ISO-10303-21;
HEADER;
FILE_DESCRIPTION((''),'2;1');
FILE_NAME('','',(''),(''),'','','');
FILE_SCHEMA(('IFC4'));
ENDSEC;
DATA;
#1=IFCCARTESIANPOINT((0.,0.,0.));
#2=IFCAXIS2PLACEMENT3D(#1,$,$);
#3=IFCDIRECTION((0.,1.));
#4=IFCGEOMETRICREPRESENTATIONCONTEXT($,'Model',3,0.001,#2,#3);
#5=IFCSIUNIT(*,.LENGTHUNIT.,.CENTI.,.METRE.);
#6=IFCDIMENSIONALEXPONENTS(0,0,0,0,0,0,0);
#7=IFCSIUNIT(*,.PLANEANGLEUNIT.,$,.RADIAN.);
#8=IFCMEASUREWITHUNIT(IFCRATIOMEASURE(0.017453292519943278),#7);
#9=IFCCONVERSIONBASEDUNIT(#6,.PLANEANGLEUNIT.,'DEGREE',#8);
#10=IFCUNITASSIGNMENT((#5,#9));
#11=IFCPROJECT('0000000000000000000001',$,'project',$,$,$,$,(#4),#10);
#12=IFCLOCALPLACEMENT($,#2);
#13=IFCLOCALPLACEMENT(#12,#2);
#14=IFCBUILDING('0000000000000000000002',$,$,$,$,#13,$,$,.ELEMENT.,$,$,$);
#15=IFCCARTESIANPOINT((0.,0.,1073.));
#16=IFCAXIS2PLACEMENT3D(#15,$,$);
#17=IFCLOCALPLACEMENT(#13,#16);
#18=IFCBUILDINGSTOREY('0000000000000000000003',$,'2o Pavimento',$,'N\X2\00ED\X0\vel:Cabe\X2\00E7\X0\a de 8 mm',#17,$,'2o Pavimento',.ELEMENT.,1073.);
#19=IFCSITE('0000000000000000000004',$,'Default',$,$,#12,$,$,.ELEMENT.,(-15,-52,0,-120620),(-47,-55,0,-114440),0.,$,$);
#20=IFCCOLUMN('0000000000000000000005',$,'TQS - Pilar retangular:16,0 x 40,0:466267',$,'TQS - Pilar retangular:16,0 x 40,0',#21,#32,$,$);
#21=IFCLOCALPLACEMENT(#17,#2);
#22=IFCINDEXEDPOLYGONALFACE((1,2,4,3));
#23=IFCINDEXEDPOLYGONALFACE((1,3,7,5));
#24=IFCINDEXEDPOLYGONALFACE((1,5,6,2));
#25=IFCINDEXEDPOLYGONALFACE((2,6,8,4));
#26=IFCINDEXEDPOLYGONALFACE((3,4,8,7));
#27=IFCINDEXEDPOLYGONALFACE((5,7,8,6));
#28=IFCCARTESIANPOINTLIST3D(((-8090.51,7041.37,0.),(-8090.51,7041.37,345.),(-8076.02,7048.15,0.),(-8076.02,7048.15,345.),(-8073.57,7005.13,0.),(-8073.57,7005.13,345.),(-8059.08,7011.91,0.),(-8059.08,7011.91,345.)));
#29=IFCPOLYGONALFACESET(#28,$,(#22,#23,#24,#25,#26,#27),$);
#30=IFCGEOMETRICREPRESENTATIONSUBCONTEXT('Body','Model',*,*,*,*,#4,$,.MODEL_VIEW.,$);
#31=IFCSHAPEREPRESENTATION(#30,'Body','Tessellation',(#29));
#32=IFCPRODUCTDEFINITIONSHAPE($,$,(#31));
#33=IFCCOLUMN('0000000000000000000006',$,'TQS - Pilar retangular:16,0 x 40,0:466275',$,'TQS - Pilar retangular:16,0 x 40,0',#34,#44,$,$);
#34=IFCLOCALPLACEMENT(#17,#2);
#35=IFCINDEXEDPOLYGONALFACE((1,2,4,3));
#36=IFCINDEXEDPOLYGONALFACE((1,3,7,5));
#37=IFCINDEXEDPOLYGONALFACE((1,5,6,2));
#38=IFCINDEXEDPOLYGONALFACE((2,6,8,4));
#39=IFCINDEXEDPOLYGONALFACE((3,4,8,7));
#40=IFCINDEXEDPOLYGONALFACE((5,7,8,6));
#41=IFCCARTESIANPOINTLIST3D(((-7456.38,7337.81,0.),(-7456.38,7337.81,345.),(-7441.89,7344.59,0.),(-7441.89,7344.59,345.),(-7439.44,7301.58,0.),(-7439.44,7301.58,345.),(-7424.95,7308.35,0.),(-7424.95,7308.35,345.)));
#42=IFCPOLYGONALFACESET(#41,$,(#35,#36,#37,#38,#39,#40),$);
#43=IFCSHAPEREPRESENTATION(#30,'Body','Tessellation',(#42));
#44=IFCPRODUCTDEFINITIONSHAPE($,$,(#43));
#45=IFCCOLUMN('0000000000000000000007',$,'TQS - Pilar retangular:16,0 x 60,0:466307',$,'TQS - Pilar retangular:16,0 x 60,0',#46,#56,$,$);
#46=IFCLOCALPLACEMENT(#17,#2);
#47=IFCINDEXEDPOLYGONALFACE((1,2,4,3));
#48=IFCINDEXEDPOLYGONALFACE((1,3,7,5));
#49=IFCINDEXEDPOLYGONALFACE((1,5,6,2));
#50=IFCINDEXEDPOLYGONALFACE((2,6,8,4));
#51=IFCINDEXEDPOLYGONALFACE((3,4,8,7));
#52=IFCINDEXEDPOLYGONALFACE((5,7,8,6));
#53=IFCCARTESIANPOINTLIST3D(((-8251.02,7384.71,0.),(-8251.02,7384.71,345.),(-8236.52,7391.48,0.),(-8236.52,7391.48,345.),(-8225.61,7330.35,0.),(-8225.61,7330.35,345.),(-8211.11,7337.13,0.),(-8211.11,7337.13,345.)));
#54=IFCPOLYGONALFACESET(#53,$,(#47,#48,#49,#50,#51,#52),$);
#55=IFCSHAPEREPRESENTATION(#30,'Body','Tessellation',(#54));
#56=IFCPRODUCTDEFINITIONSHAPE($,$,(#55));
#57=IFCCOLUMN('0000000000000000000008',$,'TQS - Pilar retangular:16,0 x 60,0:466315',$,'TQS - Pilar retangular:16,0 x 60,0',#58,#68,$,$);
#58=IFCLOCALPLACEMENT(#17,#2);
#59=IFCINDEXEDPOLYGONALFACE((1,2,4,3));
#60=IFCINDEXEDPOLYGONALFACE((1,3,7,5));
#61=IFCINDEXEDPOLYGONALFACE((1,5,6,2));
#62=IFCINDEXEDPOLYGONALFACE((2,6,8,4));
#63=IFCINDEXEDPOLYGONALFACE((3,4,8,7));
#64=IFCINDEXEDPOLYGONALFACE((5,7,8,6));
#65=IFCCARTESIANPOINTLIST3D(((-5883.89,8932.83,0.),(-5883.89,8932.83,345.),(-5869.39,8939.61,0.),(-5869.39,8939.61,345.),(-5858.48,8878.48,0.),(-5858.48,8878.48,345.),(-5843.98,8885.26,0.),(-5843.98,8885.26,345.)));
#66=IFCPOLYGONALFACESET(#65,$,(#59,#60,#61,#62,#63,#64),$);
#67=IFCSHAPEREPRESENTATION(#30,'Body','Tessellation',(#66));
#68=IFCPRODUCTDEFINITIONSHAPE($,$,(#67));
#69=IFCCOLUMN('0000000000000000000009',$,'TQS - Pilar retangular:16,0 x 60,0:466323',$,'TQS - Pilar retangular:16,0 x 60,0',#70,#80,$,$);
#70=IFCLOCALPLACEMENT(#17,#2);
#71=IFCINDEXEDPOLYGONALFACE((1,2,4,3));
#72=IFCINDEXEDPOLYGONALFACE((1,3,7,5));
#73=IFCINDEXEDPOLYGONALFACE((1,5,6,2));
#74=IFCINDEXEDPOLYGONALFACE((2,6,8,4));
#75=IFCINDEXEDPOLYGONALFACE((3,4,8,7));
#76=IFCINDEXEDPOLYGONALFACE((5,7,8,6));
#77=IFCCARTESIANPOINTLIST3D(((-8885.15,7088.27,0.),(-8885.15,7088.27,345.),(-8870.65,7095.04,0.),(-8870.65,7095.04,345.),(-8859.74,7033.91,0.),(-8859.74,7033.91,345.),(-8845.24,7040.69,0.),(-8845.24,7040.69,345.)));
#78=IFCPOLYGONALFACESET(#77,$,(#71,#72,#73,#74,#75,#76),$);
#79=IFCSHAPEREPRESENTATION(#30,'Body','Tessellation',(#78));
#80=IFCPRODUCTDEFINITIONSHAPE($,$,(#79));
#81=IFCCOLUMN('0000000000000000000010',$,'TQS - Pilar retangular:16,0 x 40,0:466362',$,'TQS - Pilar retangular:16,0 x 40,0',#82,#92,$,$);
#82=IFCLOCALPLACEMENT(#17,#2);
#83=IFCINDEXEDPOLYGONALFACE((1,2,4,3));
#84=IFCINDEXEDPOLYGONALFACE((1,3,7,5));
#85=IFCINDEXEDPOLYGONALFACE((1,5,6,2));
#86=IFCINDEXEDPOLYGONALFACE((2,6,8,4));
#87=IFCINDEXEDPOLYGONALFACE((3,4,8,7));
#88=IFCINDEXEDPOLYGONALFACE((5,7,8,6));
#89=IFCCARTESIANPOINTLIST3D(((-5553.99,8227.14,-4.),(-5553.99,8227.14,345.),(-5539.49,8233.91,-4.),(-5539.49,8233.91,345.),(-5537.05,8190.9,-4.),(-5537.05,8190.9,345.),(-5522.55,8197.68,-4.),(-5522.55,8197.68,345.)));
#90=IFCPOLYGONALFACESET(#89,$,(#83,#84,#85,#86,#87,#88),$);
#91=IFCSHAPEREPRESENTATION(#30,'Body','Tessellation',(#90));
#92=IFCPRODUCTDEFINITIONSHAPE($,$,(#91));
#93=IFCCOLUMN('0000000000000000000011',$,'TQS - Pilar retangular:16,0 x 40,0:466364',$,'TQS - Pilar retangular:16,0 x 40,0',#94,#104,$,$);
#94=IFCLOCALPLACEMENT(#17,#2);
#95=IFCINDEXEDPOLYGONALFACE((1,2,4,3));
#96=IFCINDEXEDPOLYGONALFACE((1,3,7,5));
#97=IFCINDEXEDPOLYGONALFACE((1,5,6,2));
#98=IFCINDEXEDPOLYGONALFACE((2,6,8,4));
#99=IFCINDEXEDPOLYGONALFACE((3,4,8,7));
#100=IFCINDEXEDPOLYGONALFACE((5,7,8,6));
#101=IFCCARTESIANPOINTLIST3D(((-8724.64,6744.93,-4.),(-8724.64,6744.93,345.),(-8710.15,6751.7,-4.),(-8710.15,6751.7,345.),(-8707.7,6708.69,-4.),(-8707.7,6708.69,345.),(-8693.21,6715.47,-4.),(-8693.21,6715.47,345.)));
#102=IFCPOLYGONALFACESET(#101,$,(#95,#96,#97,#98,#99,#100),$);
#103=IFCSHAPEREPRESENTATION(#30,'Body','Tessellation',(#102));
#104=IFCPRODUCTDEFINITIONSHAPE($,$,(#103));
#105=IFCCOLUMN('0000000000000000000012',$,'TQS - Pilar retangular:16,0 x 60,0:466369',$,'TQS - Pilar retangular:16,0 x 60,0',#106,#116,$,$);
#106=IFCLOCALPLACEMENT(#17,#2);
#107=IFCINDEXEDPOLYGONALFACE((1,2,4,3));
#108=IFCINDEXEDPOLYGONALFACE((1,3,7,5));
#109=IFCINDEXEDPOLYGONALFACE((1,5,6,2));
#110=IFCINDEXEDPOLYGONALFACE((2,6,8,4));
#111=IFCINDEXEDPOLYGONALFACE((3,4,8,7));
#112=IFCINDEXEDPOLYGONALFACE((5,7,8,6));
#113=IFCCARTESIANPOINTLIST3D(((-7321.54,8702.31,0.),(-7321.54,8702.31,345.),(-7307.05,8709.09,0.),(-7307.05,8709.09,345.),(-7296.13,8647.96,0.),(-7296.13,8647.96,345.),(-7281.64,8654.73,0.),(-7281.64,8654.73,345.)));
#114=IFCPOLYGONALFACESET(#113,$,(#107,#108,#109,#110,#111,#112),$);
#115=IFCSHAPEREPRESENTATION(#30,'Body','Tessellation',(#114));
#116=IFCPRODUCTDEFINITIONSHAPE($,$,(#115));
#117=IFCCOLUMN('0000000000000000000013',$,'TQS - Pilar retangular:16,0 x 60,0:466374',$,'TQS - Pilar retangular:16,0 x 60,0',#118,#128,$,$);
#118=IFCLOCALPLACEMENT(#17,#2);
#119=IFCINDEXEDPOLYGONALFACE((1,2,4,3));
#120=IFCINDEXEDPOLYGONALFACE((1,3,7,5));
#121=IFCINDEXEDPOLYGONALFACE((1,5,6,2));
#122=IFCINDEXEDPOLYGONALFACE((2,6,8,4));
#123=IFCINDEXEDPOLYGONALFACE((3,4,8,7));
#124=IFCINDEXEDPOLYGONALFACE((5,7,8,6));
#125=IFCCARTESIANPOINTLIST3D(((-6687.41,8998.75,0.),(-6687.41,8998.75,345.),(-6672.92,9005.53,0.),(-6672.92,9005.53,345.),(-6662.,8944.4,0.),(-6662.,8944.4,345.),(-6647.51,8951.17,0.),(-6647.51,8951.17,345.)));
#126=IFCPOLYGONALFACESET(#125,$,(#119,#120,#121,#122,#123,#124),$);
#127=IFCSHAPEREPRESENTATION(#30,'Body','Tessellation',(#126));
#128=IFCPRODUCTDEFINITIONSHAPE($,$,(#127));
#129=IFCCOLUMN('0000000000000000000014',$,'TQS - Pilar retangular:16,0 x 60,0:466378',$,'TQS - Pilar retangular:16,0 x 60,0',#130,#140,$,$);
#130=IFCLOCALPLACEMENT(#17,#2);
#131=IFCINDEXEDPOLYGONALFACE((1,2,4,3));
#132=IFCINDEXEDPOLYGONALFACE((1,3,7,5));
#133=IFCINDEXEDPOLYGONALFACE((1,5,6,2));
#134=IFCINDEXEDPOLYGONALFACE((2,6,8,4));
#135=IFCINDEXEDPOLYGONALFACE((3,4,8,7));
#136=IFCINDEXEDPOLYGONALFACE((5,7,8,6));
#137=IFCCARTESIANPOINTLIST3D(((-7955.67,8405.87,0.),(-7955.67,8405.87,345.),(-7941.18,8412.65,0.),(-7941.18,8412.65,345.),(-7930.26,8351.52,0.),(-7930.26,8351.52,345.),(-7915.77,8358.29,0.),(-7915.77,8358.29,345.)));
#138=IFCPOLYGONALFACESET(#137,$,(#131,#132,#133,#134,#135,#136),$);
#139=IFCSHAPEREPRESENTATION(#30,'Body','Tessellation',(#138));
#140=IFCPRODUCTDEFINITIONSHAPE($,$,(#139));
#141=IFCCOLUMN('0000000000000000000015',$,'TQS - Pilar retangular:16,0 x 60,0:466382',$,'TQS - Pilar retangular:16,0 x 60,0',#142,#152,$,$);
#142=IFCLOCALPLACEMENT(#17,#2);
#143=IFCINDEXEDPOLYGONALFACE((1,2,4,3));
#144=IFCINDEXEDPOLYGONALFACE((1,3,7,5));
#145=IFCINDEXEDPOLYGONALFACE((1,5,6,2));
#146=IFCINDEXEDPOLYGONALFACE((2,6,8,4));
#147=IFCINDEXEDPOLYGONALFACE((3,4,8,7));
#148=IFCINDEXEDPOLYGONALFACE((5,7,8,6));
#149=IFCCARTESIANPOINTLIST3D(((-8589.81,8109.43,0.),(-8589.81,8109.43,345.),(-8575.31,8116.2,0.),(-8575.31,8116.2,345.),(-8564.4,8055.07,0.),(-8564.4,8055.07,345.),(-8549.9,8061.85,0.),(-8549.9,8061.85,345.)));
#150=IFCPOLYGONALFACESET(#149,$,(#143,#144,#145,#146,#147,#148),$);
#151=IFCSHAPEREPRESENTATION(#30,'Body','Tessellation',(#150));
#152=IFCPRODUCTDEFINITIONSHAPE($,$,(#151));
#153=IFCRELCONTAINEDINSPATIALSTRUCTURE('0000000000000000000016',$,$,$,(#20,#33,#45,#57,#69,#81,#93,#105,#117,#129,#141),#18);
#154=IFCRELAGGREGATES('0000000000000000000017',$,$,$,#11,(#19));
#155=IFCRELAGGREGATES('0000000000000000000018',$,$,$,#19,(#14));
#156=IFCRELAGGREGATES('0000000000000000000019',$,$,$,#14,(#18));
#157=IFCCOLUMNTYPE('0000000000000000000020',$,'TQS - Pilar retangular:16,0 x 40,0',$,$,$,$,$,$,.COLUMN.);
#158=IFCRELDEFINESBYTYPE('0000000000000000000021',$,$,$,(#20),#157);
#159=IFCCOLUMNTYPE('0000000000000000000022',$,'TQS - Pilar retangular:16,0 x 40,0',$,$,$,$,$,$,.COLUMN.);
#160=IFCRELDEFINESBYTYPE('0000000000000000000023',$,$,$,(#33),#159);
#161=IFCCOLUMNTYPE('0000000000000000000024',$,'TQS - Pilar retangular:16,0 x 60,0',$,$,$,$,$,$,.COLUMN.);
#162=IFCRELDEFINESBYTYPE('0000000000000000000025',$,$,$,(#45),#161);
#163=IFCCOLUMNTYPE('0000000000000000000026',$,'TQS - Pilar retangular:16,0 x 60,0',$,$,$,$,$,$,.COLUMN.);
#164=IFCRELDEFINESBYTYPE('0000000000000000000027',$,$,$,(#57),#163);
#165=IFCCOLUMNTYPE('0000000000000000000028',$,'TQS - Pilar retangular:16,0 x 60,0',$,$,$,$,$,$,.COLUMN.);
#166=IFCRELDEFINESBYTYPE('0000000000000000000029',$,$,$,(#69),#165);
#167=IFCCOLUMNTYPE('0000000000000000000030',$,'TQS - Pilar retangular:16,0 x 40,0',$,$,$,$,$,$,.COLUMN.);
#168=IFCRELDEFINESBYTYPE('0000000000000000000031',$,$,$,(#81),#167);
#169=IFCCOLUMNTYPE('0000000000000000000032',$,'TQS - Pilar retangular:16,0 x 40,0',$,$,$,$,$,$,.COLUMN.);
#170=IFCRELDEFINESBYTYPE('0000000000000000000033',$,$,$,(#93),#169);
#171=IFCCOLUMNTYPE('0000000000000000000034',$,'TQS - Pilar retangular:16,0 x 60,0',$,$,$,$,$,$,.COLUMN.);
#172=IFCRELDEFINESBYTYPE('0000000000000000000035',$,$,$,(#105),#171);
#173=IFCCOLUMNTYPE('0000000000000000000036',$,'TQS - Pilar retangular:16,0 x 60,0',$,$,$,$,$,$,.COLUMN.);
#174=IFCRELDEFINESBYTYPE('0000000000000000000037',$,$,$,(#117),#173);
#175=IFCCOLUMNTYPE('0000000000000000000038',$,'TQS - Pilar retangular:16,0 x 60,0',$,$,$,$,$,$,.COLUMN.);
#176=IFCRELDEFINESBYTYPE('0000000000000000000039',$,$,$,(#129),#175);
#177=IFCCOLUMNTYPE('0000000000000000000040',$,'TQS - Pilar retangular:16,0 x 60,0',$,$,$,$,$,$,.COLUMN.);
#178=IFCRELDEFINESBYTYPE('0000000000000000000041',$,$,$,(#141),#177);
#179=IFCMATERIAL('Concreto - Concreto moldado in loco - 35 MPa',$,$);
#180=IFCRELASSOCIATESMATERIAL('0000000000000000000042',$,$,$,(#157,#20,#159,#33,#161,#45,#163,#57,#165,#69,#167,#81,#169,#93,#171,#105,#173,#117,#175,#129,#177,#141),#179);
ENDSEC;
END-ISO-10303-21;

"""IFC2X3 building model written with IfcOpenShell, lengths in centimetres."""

from ifc_helpers import new_model, entity, si_unit, converted_unit, direction, frame, frame_2d, origin, origin_2d_with_axis, place, context, subcontext, project, spatial, rectangle, extrude, source, transform, mapped, material, type_object, type_shapes, element, save


model = new_model("IFC2X3")

# Units and contexts
model_context = context("Model", 3, precision=0.001, world=origin(), true_north=direction((0.0, 1.0)))
body_context = subcontext(model_context, "Body", "Model", "MODEL_VIEW")
ifc_project = project(units=[si_unit("LENGTHUNIT", "METRE", prefix="CENTI"), converted_unit("PLANEANGLEUNIT", "DEGREE", entity("IfcRatioMeasure", 0.017453292519943278), si_unit("PLANEANGLEUNIT", "RADIAN"), dimensions=[0, 0, 0, 0, 0, 0, 0])], contexts=[model_context])

# Site, building, storey
site_placement = place(None, origin())
site = spatial("IfcSite", under=ifc_project, at=site_placement, Name="Default", CompositionType="ELEMENT", RefLatitude=(-15, -52, 0, -120620), RefLongitude=(-47, -55, 0, -114440), RefElevation=0.0)
building_placement = place(site_placement, origin())
building = spatial("IfcBuilding", under=site, at=building_placement, CompositionType="ELEMENT")
storey_placement = place(building_placement, frame((0.0, 0.0, 1073.0)))
storey = spatial("IfcBuildingStorey", under=building, at=storey_placement, Name="2o Pavimento", ObjectType="Nível:Cabeça de 8 mm", LongName="2o Pavimento", CompositionType="ELEMENT", Elevation=1073.0)

# Columns
ifc_material = material(Name="Concreto - Concreto moldado in loco - 35 MPa")
column_type_1 = type_object("IfcColumnType", Name="TQS - Pilar retangular:16,0 x 40,0", PredefinedType="COLUMN", material=ifc_material)
shared_shape_1 = source(origin(), body_context, "Body", "SweptSolid", [
    extrude(rectangle(XDim=40.0, YDim=16.0, at=origin_2d_with_axis()), frame((-8074.8, 7026.64, 1073.0), z_axis=(0.0, 0.0, 1.0), x_axis=(-0.423488, 0.905902, 0.0)), (0.0, 0.0, 1.0), 345.0),
])
type_shapes(column_type_1, [shared_shape_1])
column_1_placement = place(storey_placement, frame((0.0, 0.0, -1073.0)))
element("IfcColumn", 1, at=column_1_placement, inside=storey, type_object=column_type_1, material=ifc_material, Name="TQS - Pilar retangular:16,0 x 40,0:466267", ObjectType="TQS - Pilar retangular:16,0 x 40,0", context=body_context, shape_type="MappedRepresentation", body=[
    mapped(shared_shape_1, transform((0.0, 0.0, 0.0), scale=1.0)),
])
column_type_2 = type_object("IfcColumnType", Name="TQS - Pilar retangular:16,0 x 40,0", PredefinedType="COLUMN", material=ifc_material)
shared_shape_2 = source(origin(), body_context, "Body", "SweptSolid", [
    extrude(rectangle(XDim=40.0, YDim=16.0, at=origin_2d_with_axis()), frame((-7440.67, 7323.08, 1073.0), z_axis=(0.0, 0.0, 1.0), x_axis=(-0.423488, 0.905902, 0.0)), (0.0, 0.0, 1.0), 345.0),
])
type_shapes(column_type_2, [shared_shape_2])
column_2_placement = place(storey_placement, frame((0.0, 0.0, -1073.0)))
element("IfcColumn", 2, at=column_2_placement, inside=storey, type_object=column_type_2, material=ifc_material, Name="TQS - Pilar retangular:16,0 x 40,0:466275", ObjectType="TQS - Pilar retangular:16,0 x 40,0", context=body_context, shape_type="MappedRepresentation", body=[
    mapped(shared_shape_2, transform((0.0, 0.0, 0.0), scale=1.0)),
])
column_type_3 = type_object("IfcColumnType", Name="TQS - Pilar retangular:16,0 x 60,0", PredefinedType="COLUMN", material=ifc_material)
shared_shape_3 = source(origin(), body_context, "Body", "SweptSolid", [
    extrude(rectangle(XDim=60.0, YDim=16.0, at=origin_2d_with_axis()), frame((-8231.06, 7360.92, 1073.0), z_axis=(0.0, 0.0, 1.0), x_axis=(-0.423488, 0.905902, 0.0)), (0.0, 0.0, 1.0), 345.0),
])
type_shapes(column_type_3, [shared_shape_3])
column_3_placement = place(storey_placement, frame((0.0, 0.0, -1073.0)))
element("IfcColumn", 3, at=column_3_placement, inside=storey, type_object=column_type_3, material=ifc_material, Name="TQS - Pilar retangular:16,0 x 60,0:466307", ObjectType="TQS - Pilar retangular:16,0 x 60,0", context=body_context, shape_type="MappedRepresentation", body=[
    mapped(shared_shape_3, transform((0.0, 0.0, 0.0), scale=1.0)),
])
column_type_4 = type_object("IfcColumnType", Name="TQS - Pilar retangular:16,0 x 60,0", PredefinedType="COLUMN", material=ifc_material)
shared_shape_4 = source(origin(), body_context, "Body", "SweptSolid", [
    extrude(rectangle(XDim=60.0, YDim=16.0, at=origin_2d_with_axis()), frame((-5863.93, 8909.04, 1073.0), z_axis=(0.0, 0.0, 1.0), x_axis=(-0.423488, 0.905902, 0.0)), (0.0, 0.0, 1.0), 345.0),
])
type_shapes(column_type_4, [shared_shape_4])
column_4_placement = place(storey_placement, frame((0.0, 0.0, -1073.0)))
element("IfcColumn", 4, at=column_4_placement, inside=storey, type_object=column_type_4, material=ifc_material, Name="TQS - Pilar retangular:16,0 x 60,0:466315", ObjectType="TQS - Pilar retangular:16,0 x 60,0", context=body_context, shape_type="MappedRepresentation", body=[
    mapped(shared_shape_4, transform((0.0, 0.0, 0.0), scale=1.0)),
])
column_type_5 = type_object("IfcColumnType", Name="TQS - Pilar retangular:16,0 x 60,0", PredefinedType="COLUMN", material=ifc_material)
shared_shape_5 = source(origin(), body_context, "Body", "SweptSolid", [
    extrude(rectangle(XDim=60.0, YDim=16.0, at=origin_2d_with_axis()), frame((-8865.19, 7064.48, 1073.0), z_axis=(0.0, 0.0, 1.0), x_axis=(-0.423488, 0.905902, 0.0)), (0.0, 0.0, 1.0), 345.0),
])
type_shapes(column_type_5, [shared_shape_5])
column_5_placement = place(storey_placement, frame((0.0, 0.0, -1073.0)))
element("IfcColumn", 5, at=column_5_placement, inside=storey, type_object=column_type_5, material=ifc_material, Name="TQS - Pilar retangular:16,0 x 60,0:466323", ObjectType="TQS - Pilar retangular:16,0 x 60,0", context=body_context, shape_type="MappedRepresentation", body=[
    mapped(shared_shape_5, transform((0.0, 0.0, 0.0), scale=1.0)),
])
column_type_6 = type_object("IfcColumnType", Name="TQS - Pilar retangular:16,0 x 40,0", PredefinedType="COLUMN", material=ifc_material)
shared_shape_6 = source(origin(), body_context, "Body", "SweptSolid", [
    extrude(rectangle(XDim=40.0, YDim=16.0, at=origin_2d_with_axis()), frame((-5538.27, 8212.41, 1069.0), z_axis=(0.0, 0.0, 1.0), x_axis=(-0.423488, 0.905902, 0.0)), (0.0, 0.0, 1.0), 349.0),
])
type_shapes(column_type_6, [shared_shape_6])
column_6_placement = place(storey_placement, frame((0.0, 0.0, -1073.0)))
element("IfcColumn", 6, at=column_6_placement, inside=storey, type_object=column_type_6, material=ifc_material, Name="TQS - Pilar retangular:16,0 x 40,0:466362", ObjectType="TQS - Pilar retangular:16,0 x 40,0", context=body_context, shape_type="MappedRepresentation", body=[
    mapped(shared_shape_6, transform((0.0, 0.0, 0.0), scale=1.0)),
])
column_type_7 = type_object("IfcColumnType", Name="TQS - Pilar retangular:16,0 x 40,0", PredefinedType="COLUMN", material=ifc_material)
shared_shape_7 = source(origin(), body_context, "Body", "SweptSolid", [
    extrude(rectangle(XDim=40.0, YDim=16.0, at=origin_2d_with_axis()), frame((-8708.93, 6730.2, 1069.0), z_axis=(0.0, 0.0, 1.0), x_axis=(-0.423488, 0.905902, 0.0)), (0.0, 0.0, 1.0), 349.0),
])
type_shapes(column_type_7, [shared_shape_7])
column_7_placement = place(storey_placement, frame((0.0, 0.0, -1073.0)))
element("IfcColumn", 7, at=column_7_placement, inside=storey, type_object=column_type_7, material=ifc_material, Name="TQS - Pilar retangular:16,0 x 40,0:466364", ObjectType="TQS - Pilar retangular:16,0 x 40,0", context=body_context, shape_type="MappedRepresentation", body=[
    mapped(shared_shape_7, transform((0.0, 0.0, 0.0), scale=1.0)),
])
column_type_8 = type_object("IfcColumnType", Name="TQS - Pilar retangular:16,0 x 60,0", PredefinedType="COLUMN", material=ifc_material)
shared_shape_8 = source(origin(), body_context, "Body", "SweptSolid", [
    extrude(rectangle(XDim=60.0, YDim=16.0, at=origin_2d_with_axis()), frame((-7301.59, 8678.52, 1073.0), z_axis=(0.0, 0.0, 1.0), x_axis=(-0.423488, 0.905902, 0.0)), (0.0, 0.0, 1.0), 345.0),
])
type_shapes(column_type_8, [shared_shape_8])
column_8_placement = place(storey_placement, frame((0.0, 0.0, -1073.0)))
element("IfcColumn", 8, at=column_8_placement, inside=storey, type_object=column_type_8, material=ifc_material, Name="TQS - Pilar retangular:16,0 x 60,0:466369", ObjectType="TQS - Pilar retangular:16,0 x 60,0", context=body_context, shape_type="MappedRepresentation", body=[
    mapped(shared_shape_8, transform((0.0, 0.0, 0.0), scale=1.0)),
])
column_type_9 = type_object("IfcColumnType", Name="TQS - Pilar retangular:16,0 x 60,0", PredefinedType="COLUMN", material=ifc_material)
shared_shape_9 = source(origin(), body_context, "Body", "SweptSolid", [
    extrude(rectangle(XDim=60.0, YDim=16.0, at=frame_2d((0.0, 0.0), x_axis=(1.0, 0.0))), frame((-6667.46, 8974.96, 1073.0), z_axis=(0.0, 0.0, 1.0), x_axis=(-0.423488, 0.905902, 0.0)), (0.0, 0.0, 1.0), 345.0),
])
type_shapes(column_type_9, [shared_shape_9])
column_9_placement = place(storey_placement, frame((0.0, 0.0, -1073.0)))
element("IfcColumn", 9, at=column_9_placement, inside=storey, type_object=column_type_9, material=ifc_material, Name="TQS - Pilar retangular:16,0 x 60,0:466374", ObjectType="TQS - Pilar retangular:16,0 x 60,0", context=body_context, shape_type="MappedRepresentation", body=[
    mapped(shared_shape_9, transform((0.0, 0.0, 0.0), scale=1.0)),
])
column_type_10 = type_object("IfcColumnType", Name="TQS - Pilar retangular:16,0 x 60,0", PredefinedType="COLUMN", material=ifc_material)
shared_shape_10 = source(origin(), body_context, "Body", "SweptSolid", [
    extrude(rectangle(XDim=60.0, YDim=16.0, at=origin_2d_with_axis()), frame((-7935.72, 8382.08, 1073.0), z_axis=(0.0, 0.0, 1.0), x_axis=(-0.423488, 0.905902, 0.0)), (0.0, 0.0, 1.0), 345.0),
])
type_shapes(column_type_10, [shared_shape_10])
column_10_placement = place(storey_placement, frame((0.0, 0.0, -1073.0)))
element("IfcColumn", 10, at=column_10_placement, inside=storey, type_object=column_type_10, material=ifc_material, Name="TQS - Pilar retangular:16,0 x 60,0:466378", ObjectType="TQS - Pilar retangular:16,0 x 60,0", context=body_context, shape_type="MappedRepresentation", body=[
    mapped(shared_shape_10, transform((0.0, 0.0, 0.0), scale=1.0)),
])
column_type_11 = type_object("IfcColumnType", Name="TQS - Pilar retangular:16,0 x 60,0", PredefinedType="COLUMN", material=ifc_material)
shared_shape_11 = source(origin(), body_context, "Body", "SweptSolid", [
    extrude(rectangle(XDim=60.0, YDim=16.0, at=origin_2d_with_axis()), frame((-8569.85, 8085.64, 1073.0), z_axis=(0.0, 0.0, 1.0), x_axis=(-0.423488, 0.905902, 0.0)), (0.0, 0.0, 1.0), 345.0),
])
type_shapes(column_type_11, [shared_shape_11])
column_11_placement = place(storey_placement, frame((0.0, 0.0, -1073.0)))
element("IfcColumn", 11, at=column_11_placement, inside=storey, type_object=column_type_11, material=ifc_material, Name="TQS - Pilar retangular:16,0 x 60,0:466382", ObjectType="TQS - Pilar retangular:16,0 x 60,0", context=body_context, shape_type="MappedRepresentation", body=[
    mapped(shared_shape_11, transform((0.0, 0.0, 0.0), scale=1.0)),
])

save(model, "model.ifc")
